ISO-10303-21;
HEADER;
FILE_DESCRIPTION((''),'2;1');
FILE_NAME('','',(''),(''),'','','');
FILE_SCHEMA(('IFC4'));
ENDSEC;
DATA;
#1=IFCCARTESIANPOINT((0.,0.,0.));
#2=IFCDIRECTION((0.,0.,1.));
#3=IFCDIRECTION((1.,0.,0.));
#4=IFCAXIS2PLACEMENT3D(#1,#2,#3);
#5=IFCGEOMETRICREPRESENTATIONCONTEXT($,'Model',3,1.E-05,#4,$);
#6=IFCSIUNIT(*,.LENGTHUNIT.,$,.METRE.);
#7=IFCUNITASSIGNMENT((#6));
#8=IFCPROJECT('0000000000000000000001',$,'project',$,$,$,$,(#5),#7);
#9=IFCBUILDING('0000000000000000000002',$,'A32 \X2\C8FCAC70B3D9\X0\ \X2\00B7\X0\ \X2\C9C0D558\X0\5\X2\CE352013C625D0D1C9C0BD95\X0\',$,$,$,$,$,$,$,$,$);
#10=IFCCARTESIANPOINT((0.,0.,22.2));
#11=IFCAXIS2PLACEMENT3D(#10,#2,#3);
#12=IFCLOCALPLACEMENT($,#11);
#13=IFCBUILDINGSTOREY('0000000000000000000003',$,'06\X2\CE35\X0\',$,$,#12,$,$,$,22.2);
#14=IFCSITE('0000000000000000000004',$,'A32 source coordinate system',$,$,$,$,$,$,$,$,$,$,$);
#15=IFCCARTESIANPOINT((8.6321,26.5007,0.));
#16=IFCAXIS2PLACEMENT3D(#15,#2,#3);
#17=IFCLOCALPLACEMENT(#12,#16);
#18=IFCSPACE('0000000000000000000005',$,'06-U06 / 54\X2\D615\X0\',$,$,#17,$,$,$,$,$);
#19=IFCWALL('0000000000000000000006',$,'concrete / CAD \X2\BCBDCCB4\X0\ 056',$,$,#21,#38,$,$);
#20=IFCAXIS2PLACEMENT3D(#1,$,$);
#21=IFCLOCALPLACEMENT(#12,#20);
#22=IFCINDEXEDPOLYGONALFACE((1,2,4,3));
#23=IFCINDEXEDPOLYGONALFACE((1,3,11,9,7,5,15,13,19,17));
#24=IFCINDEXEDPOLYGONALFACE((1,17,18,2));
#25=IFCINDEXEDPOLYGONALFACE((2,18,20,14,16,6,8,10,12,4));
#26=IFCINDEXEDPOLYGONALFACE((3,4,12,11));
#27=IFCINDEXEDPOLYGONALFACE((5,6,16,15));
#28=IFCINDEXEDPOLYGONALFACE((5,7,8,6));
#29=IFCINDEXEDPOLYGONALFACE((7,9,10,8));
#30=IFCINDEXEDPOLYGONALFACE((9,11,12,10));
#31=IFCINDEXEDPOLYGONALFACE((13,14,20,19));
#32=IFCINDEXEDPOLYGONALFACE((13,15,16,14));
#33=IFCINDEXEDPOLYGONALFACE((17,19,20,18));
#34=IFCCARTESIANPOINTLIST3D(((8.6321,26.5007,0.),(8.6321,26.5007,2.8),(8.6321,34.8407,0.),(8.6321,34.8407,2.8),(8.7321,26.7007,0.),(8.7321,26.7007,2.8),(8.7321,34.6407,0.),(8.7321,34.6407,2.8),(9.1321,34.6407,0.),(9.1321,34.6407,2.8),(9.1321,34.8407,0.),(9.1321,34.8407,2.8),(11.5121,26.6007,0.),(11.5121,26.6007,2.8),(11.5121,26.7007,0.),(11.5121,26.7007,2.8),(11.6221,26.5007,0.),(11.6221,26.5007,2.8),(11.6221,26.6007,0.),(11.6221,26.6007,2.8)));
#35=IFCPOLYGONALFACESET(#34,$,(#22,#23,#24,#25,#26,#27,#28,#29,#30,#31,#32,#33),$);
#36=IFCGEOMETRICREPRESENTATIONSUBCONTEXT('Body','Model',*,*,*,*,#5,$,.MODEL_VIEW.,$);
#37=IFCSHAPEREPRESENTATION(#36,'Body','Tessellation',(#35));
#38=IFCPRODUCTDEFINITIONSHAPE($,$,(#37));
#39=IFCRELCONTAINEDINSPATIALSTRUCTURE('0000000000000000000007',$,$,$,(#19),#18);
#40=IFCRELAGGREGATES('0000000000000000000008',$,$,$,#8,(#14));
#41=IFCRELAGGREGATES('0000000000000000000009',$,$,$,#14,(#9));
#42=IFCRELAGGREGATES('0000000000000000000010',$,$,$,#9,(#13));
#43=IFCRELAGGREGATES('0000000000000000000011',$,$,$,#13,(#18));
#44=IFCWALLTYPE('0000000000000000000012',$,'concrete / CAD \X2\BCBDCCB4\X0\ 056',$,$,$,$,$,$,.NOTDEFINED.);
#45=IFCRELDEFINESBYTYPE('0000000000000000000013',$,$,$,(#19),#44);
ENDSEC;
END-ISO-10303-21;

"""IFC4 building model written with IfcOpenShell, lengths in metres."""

from ifc_helpers import new_model, si_unit, frame, origin, origin_with_axes, place, context, subcontext, project, spatial, polyline, outline, extrude, source, transform, mapped, type_object, type_shapes, element, save


model = new_model("IFC4")

# Units and contexts
model_context = context("Model", 3, precision=1e-05, world=origin_with_axes())
body_context = subcontext(model_context, "Body", "Model", "MODEL_VIEW")
ifc_project = project(units=[si_unit("LENGTHUNIT", "METRE")], contexts=[model_context])

# Site, building, storey, space
site = spatial("IfcSite", under=ifc_project, Name="A32 source coordinate system")
building = spatial("IfcBuilding", under=site, Name="A32 주거동 · 지하5층–옥탑지붕")
storey_placement = place(None, frame((0.0, 0.0, 22.2), z_axis=(0.0, 0.0, 1.0), x_axis=(1.0, 0.0, 0.0)))
storey = spatial("IfcBuildingStorey", under=building, at=storey_placement, Name="06층", Elevation=22.2)
space_placement = place(storey_placement, frame((8.6321, 26.5007, 0.0), z_axis=(0.0, 0.0, 1.0), x_axis=(1.0, 0.0, 0.0)))
space = spatial("IfcSpace", under=storey, at=space_placement, Name="06-U06 / 54형")

# Wall
wall_type_1 = type_object("IfcWallType", Name="concrete / CAD 벽체 056", PredefinedType="NOTDEFINED")
shared_shape_1 = source(origin(), body_context, "Body", "SweptSolid", [
    extrude(outline(polyline([(0.1, 8.14), (0.1, 0.2), (2.88, 0.2), (2.88, 0.1), (2.99, 0.1), (2.99, 0.0), (0.0, 0.0), (0.0, 8.34), (-0.35, 8.34), (-0.35, 8.34), (0.5, 8.34), (0.5, 8.14), (0.1, 8.14)])), origin(), (0.0, 0.0, 1.0), 2.8),
])
type_shapes(wall_type_1, [shared_shape_1])
wall_1_placement = place(space_placement, origin_with_axes())
element("IfcWall", 1, at=wall_1_placement, inside=space, type_object=wall_type_1, Name="concrete / CAD 벽체 056", context=body_context, shape_type="MappedRepresentation", body=[
    mapped(shared_shape_1, transform((0.0, 0.0, 0.0), scale=1.0)),
])

save(model, "model.ifc")
